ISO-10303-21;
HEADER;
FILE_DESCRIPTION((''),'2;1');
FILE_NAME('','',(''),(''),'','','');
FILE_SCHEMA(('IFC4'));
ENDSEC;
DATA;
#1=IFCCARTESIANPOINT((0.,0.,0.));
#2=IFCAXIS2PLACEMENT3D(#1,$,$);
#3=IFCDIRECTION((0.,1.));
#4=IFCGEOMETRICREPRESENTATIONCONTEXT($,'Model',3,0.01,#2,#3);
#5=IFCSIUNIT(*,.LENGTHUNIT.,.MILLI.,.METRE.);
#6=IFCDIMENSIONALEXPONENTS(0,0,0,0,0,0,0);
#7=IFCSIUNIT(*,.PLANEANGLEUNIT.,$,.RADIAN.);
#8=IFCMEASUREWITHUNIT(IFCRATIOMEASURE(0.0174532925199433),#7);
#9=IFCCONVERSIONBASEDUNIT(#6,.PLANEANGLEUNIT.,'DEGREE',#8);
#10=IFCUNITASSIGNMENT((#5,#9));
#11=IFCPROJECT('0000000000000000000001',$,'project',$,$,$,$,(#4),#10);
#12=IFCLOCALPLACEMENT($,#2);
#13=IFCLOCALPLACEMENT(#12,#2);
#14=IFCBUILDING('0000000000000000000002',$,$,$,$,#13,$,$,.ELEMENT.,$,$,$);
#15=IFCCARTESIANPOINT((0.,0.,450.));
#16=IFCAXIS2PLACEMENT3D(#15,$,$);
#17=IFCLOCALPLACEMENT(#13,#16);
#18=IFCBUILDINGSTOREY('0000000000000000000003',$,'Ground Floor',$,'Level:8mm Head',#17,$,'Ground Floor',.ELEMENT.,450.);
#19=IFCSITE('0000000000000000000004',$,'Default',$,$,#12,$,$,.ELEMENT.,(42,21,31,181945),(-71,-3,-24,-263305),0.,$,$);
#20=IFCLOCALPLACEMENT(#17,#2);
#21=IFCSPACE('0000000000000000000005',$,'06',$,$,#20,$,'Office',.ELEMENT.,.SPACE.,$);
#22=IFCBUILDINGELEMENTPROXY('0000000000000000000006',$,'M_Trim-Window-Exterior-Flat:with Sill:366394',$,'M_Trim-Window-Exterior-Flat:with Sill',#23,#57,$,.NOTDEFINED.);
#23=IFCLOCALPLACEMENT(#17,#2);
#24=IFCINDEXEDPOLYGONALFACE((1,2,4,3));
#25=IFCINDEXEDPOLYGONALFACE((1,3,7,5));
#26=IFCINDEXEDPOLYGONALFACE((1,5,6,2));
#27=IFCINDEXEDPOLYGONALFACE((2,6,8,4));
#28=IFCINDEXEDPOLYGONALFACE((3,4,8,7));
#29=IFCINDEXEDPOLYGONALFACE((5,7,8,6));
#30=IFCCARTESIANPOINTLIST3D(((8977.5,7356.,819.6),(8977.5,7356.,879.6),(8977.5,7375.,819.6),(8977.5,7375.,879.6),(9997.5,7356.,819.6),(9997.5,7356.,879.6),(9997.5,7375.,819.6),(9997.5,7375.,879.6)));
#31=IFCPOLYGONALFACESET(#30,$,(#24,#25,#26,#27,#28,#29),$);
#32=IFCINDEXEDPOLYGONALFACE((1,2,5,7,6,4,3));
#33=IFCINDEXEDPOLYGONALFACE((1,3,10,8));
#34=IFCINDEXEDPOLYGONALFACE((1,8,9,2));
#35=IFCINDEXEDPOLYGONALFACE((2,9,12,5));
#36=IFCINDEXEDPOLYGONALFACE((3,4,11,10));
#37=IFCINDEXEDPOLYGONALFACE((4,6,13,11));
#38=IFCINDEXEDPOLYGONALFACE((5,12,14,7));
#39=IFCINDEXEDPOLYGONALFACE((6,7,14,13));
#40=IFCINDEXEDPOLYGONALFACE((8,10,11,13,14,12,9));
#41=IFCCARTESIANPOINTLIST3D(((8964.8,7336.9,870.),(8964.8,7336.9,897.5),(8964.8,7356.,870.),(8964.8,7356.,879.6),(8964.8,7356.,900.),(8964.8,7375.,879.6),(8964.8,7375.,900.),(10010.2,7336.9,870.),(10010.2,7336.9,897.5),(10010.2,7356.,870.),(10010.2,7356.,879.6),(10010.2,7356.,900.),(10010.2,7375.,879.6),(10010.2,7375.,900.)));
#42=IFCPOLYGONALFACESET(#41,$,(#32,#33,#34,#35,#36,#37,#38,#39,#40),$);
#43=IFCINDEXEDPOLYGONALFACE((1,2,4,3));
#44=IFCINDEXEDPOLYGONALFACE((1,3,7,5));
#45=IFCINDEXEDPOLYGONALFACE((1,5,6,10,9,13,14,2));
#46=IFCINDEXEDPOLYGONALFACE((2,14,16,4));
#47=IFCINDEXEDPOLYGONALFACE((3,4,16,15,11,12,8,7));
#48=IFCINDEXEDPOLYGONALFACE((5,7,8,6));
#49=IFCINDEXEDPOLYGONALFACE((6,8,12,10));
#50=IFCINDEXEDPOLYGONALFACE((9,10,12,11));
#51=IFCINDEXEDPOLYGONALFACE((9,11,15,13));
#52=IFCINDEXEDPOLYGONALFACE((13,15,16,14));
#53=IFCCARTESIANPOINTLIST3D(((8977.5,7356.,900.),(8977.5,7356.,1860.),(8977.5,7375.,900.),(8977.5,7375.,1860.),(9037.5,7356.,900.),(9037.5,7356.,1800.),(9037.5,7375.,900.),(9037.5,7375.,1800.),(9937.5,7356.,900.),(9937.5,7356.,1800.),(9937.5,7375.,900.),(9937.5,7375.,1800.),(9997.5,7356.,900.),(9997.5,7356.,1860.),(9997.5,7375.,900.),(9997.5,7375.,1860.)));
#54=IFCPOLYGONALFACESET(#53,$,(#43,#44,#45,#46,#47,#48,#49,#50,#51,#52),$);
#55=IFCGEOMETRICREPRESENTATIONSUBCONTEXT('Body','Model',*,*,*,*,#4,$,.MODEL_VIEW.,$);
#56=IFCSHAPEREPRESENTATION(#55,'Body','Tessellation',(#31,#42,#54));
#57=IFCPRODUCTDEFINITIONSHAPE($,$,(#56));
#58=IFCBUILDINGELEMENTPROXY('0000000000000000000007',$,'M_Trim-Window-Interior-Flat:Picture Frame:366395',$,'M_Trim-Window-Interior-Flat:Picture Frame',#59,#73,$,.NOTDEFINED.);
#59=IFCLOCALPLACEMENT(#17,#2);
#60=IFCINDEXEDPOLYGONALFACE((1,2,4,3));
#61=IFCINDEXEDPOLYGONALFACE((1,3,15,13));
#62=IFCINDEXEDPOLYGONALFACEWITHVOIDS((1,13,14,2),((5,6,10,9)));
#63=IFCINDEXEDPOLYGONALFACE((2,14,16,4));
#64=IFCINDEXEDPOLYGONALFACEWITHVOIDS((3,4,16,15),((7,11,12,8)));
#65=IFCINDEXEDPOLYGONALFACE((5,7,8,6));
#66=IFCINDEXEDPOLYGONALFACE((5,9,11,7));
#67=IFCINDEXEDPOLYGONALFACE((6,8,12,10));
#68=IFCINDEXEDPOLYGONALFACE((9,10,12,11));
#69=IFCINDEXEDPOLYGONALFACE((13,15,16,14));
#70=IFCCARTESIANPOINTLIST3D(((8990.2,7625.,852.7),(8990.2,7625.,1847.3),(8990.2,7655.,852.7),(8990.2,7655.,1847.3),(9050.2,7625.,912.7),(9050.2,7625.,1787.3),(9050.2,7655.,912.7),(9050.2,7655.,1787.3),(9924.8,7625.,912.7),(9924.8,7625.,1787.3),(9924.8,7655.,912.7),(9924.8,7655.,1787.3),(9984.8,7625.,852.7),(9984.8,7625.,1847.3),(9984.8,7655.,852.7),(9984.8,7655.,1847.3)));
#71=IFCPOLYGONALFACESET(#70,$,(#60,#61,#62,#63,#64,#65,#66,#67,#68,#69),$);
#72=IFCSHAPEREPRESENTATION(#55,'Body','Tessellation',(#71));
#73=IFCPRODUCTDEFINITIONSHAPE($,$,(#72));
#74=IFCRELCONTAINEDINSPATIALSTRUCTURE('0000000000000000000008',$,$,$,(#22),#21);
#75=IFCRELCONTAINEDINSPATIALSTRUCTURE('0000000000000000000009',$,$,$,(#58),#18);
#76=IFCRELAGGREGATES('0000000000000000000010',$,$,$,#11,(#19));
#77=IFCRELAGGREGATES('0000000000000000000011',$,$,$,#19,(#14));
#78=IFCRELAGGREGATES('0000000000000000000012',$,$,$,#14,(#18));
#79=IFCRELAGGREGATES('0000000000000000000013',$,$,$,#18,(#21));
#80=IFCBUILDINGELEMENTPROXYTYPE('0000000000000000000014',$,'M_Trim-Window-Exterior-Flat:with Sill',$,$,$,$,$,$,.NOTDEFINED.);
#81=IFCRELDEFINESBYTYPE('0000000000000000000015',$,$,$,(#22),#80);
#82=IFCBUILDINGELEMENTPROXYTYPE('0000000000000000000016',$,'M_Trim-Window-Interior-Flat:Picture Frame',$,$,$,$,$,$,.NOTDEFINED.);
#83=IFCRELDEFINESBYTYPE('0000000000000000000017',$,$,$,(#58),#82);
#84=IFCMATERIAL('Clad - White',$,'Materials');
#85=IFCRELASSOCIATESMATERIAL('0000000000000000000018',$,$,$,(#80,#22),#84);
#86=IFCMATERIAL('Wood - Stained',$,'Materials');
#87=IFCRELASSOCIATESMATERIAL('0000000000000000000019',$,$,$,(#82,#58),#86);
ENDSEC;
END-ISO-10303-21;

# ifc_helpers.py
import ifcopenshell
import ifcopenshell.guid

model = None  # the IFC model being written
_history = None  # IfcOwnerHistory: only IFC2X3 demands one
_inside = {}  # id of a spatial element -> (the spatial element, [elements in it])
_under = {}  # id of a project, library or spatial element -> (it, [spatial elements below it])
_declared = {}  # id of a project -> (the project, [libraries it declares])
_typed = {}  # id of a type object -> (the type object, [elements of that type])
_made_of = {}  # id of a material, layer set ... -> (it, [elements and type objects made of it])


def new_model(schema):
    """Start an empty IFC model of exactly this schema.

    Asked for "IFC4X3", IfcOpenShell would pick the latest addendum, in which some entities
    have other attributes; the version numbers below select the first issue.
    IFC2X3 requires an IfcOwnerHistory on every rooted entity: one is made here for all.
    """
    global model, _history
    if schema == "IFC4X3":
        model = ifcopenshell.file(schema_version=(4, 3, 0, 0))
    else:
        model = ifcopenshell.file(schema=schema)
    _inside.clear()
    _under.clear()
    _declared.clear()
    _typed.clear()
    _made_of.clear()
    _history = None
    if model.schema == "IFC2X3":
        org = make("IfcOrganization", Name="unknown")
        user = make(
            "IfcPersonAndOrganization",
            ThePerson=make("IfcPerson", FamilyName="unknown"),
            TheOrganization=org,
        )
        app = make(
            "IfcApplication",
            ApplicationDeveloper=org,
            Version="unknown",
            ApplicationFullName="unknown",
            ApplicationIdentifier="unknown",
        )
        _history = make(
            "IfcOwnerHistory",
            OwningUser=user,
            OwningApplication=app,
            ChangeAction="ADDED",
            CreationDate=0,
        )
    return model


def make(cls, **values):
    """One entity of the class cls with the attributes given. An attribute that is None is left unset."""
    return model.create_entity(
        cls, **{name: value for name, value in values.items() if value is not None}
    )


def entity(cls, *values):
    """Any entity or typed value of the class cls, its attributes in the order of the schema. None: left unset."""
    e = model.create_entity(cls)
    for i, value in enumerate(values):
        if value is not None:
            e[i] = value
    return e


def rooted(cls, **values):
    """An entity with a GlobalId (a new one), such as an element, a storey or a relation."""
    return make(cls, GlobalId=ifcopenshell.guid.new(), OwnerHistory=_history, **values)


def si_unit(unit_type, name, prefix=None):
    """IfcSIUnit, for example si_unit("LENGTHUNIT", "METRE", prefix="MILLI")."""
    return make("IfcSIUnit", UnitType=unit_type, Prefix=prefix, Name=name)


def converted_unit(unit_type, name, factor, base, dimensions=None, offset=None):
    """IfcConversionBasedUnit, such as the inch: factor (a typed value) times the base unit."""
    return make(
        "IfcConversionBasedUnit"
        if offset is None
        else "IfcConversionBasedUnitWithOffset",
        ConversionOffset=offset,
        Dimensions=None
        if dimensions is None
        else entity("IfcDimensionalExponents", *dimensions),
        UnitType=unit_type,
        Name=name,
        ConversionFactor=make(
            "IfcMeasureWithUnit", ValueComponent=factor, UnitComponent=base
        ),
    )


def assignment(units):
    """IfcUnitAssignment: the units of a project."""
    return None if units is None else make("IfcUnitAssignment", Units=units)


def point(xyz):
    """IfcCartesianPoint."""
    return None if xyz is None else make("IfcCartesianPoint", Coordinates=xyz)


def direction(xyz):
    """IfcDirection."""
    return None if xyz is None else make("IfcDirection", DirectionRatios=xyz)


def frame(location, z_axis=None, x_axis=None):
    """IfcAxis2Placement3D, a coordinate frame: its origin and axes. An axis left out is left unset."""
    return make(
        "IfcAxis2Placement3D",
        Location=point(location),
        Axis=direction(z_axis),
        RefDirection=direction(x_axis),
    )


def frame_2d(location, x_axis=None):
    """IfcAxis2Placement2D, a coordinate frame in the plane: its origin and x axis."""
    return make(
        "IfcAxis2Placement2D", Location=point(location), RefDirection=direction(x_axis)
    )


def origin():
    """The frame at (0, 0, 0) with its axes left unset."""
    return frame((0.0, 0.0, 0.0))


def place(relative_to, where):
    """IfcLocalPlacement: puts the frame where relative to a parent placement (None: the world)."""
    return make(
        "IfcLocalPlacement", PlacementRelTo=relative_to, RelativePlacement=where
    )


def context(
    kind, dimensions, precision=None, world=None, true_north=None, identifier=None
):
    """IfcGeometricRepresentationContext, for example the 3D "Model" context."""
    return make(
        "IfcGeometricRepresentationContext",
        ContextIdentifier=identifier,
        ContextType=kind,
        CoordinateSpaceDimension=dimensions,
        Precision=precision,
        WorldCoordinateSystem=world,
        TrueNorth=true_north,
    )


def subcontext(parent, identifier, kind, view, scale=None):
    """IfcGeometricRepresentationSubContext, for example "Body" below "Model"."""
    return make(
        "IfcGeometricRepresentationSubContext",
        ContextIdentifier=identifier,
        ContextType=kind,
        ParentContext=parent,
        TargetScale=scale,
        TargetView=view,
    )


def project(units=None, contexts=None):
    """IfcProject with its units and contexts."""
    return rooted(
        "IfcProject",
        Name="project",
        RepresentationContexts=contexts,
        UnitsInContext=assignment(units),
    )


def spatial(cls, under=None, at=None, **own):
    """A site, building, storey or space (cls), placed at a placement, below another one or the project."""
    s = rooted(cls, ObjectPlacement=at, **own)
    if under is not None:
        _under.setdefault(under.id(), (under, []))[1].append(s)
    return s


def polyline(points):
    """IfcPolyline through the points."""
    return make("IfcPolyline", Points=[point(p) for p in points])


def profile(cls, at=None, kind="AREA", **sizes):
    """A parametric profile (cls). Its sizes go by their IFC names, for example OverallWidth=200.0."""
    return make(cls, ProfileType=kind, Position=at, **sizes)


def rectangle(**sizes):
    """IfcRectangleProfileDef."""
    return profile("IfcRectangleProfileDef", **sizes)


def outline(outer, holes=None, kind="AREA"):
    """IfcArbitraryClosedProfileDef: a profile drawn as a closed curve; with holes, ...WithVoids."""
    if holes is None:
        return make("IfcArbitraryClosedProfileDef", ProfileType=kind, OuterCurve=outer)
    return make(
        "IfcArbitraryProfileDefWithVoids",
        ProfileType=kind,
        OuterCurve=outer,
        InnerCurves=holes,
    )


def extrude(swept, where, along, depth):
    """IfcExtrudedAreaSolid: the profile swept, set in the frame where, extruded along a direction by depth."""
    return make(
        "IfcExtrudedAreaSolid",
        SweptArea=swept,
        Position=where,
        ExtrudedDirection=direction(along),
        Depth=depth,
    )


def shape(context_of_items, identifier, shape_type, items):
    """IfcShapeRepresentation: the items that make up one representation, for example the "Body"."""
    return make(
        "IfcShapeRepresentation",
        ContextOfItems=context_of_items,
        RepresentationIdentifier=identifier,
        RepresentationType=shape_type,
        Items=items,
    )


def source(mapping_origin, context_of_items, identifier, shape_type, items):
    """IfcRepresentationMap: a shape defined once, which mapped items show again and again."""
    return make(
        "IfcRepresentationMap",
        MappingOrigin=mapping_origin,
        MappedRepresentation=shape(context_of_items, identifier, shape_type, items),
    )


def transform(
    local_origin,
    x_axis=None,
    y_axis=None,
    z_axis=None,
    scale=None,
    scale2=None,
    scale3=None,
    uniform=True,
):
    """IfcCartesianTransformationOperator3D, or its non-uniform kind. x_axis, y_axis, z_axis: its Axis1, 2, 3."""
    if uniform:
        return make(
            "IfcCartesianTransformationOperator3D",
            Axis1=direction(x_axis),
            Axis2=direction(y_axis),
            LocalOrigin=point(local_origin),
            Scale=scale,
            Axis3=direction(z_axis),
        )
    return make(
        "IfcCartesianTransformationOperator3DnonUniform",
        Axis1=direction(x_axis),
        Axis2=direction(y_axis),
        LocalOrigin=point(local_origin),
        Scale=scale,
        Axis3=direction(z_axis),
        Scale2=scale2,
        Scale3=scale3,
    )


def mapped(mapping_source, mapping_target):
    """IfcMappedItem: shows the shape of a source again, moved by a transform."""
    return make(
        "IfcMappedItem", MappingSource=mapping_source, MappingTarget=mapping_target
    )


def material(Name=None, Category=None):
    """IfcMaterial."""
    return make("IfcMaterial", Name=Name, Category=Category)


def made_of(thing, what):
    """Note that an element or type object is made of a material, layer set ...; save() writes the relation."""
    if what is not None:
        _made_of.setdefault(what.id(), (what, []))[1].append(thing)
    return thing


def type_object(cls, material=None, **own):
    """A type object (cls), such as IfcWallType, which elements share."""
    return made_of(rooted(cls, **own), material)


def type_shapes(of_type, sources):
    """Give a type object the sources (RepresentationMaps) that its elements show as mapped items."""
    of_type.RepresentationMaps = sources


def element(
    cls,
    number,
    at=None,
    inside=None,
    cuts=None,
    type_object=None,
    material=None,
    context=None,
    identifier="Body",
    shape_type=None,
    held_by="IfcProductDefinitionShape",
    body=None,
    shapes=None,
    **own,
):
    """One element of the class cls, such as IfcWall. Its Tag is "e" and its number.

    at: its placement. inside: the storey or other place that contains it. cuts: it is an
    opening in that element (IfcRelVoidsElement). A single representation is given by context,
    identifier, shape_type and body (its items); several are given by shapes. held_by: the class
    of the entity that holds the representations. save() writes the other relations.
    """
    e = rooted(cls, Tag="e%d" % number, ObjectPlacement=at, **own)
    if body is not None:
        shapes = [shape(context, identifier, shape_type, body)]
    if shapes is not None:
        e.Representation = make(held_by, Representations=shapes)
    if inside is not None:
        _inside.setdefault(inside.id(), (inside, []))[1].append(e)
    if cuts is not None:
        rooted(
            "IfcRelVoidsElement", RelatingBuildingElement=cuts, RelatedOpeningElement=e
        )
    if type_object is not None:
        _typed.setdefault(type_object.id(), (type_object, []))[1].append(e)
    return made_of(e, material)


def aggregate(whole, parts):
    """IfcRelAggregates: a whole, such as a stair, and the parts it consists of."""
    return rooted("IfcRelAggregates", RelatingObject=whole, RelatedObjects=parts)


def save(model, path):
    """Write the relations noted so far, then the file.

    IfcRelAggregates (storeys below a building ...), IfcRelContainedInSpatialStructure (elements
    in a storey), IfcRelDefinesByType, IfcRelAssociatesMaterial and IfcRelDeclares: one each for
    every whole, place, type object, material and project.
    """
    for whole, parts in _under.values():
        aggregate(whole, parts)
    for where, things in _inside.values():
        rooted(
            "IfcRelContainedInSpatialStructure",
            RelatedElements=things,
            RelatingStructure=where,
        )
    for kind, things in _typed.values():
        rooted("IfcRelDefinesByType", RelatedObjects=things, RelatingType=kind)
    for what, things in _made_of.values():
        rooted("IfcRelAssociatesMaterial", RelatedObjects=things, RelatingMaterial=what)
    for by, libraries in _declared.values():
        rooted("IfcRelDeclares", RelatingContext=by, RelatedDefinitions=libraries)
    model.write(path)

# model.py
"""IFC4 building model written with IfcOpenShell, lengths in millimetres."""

from ifc_helpers import new_model, entity, si_unit, converted_unit, direction, frame, frame_2d, origin, place, context, subcontext, project, spatial, polyline, rectangle, outline, extrude, source, transform, mapped, material, type_object, type_shapes, element, save


model = new_model("IFC4")

# Units and contexts
model_context = context("Model", 3, precision=0.01, world=origin(), true_north=direction((0.0, 1.0)))
body_context = subcontext(model_context, "Body", "Model", "MODEL_VIEW")
ifc_project = project(units=[si_unit("LENGTHUNIT", "METRE", prefix="MILLI"), converted_unit("PLANEANGLEUNIT", "DEGREE", entity("IfcRatioMeasure", 0.0174532925199433), si_unit("PLANEANGLEUNIT", "RADIAN"), dimensions=[0, 0, 0, 0, 0, 0, 0])], contexts=[model_context])

# Site, building, storey
site_placement = place(None, origin())
site = spatial("IfcSite", under=ifc_project, at=site_placement, Name="Default", CompositionType="ELEMENT", RefLatitude=(42, 21, 31, 181945), RefLongitude=(-71, -3, -24, -263305), RefElevation=0.0)
building_placement = place(site_placement, origin())
building = spatial("IfcBuilding", under=site, at=building_placement, CompositionType="ELEMENT")
storey_placement = place(building_placement, frame((0.0, 0.0, 450.0)))
storey = spatial("IfcBuildingStorey", under=building, at=storey_placement, Name="Ground Floor", ObjectType="Level:8mm Head", LongName="Ground Floor", CompositionType="ELEMENT", Elevation=450.0)

# Shared definitions
ifc_material_1 = material(Name="Clad - White", Category="Materials")
ifc_material_2 = material(Name="Wood - Stained", Category="Materials")

# Shared definitions
space_1_placement = place(storey_placement, origin())
space_1 = spatial("IfcSpace", under=storey, at=space_1_placement, Name="06", LongName="Office", CompositionType="ELEMENT", PredefinedType="SPACE")

# Building element proxies
building_element_proxy_type_1 = type_object("IfcBuildingElementProxyType", Name="M_Trim-Window-Exterior-Flat:with Sill", PredefinedType="NOTDEFINED", material=ifc_material_1)
shared_shape_1 = source(origin(), body_context, "Body", "SweptSolid", [
    extrude(rectangle(XDim=1020.0, YDim=60.0, at=frame_2d((0.0, 0.0), x_axis=(1.0, 0.0))), frame((0.0, -950.4, 0.0), z_axis=(0.0, 0.0, 1.0), x_axis=(-1.0, 0.0, 0.0)), (0.0, 0.0, 1.0), 19.1),
    extrude(outline(polyline([(-19.0, -15.2), (0.0, -15.2), (0.0, -5.7), (19.0, -5.7), (19.0, 14.8), (0.0, 14.8), (-19.0, 12.3), (-19.0, -15.2)])), frame((-522.7, -914.8, 19.0), z_axis=(1.0, 0.0, 0.0), x_axis=(0.0, 0.0, -1.0)), (0.0, 0.0, 1.0), 1045.4),
    extrude(outline(polyline([(-495.0, -510.0), (465.0, -510.0), (465.0, -450.0), (-435.0, -450.0), (-435.0, 450.0), (465.0, 450.0), (465.0, 510.0), (-495.0, 510.0), (-495.0, -510.0)])), frame((0.0, -435.0, 0.0), z_axis=(0.0, 0.0, 1.0), x_axis=(0.0, -1.0, 0.0)), (0.0, 0.0, 1.0), 19.1),
])
type_shapes(building_element_proxy_type_1, [shared_shape_1])
proxy_1_placement = place(space_1_placement, frame((9487.5, 7375.0, 1800.0), z_axis=(0.0, -1.0, 0.0), x_axis=(1.0, 0.0, 0.0)))
element("IfcBuildingElementProxy", 1, at=proxy_1_placement, inside=space_1, type_object=building_element_proxy_type_1, material=ifc_material_1, Name="M_Trim-Window-Exterior-Flat:with Sill:366394", ObjectType="M_Trim-Window-Exterior-Flat:with Sill", PredefinedType="NOTDEFINED", context=body_context, shape_type="MappedRepresentation", body=[
    mapped(shared_shape_1, transform((0.0, 0.0, 0.0), scale=1.0)),
])
building_element_proxy_type_2 = type_object("IfcBuildingElementProxyType", Name="M_Trim-Window-Interior-Flat:Picture Frame", PredefinedType="NOTDEFINED", material=ifc_material_2)
shared_shape_2 = source(origin(), body_context, "Body", "SweptSolid", [
    extrude(outline(polyline([(-497.3, -497.3), (497.3, -497.3), (497.3, 497.3), (-497.3, 497.3), (-497.3, -497.3)]), holes=[polyline([(-437.3, -437.3), (-437.3, 437.3), (437.3, 437.3), (437.3, -437.3), (-437.3, -437.3)])]), frame((0.0, -450.0, 0.0), z_axis=(0.0, 0.0, 1.0), x_axis=(-1.0, 0.0, 0.0)), (0.0, 0.0, 1.0), 30.0),
])
type_shapes(building_element_proxy_type_2, [shared_shape_2])
proxy_2_placement = place(storey_placement, frame((9487.5, 7625.0, 1800.0), z_axis=(0.0, 1.0, 0.0), x_axis=(-1.0, 0.0, 0.0)))
element("IfcBuildingElementProxy", 2, at=proxy_2_placement, inside=storey, type_object=building_element_proxy_type_2, material=ifc_material_2, Name="M_Trim-Window-Interior-Flat:Picture Frame:366395", ObjectType="M_Trim-Window-Interior-Flat:Picture Frame", PredefinedType="NOTDEFINED", context=body_context, shape_type="MappedRepresentation", body=[
    mapped(shared_shape_2, transform((0.0, 0.0, 0.0), scale=1.0)),
])

save(model, "model.ifc")
